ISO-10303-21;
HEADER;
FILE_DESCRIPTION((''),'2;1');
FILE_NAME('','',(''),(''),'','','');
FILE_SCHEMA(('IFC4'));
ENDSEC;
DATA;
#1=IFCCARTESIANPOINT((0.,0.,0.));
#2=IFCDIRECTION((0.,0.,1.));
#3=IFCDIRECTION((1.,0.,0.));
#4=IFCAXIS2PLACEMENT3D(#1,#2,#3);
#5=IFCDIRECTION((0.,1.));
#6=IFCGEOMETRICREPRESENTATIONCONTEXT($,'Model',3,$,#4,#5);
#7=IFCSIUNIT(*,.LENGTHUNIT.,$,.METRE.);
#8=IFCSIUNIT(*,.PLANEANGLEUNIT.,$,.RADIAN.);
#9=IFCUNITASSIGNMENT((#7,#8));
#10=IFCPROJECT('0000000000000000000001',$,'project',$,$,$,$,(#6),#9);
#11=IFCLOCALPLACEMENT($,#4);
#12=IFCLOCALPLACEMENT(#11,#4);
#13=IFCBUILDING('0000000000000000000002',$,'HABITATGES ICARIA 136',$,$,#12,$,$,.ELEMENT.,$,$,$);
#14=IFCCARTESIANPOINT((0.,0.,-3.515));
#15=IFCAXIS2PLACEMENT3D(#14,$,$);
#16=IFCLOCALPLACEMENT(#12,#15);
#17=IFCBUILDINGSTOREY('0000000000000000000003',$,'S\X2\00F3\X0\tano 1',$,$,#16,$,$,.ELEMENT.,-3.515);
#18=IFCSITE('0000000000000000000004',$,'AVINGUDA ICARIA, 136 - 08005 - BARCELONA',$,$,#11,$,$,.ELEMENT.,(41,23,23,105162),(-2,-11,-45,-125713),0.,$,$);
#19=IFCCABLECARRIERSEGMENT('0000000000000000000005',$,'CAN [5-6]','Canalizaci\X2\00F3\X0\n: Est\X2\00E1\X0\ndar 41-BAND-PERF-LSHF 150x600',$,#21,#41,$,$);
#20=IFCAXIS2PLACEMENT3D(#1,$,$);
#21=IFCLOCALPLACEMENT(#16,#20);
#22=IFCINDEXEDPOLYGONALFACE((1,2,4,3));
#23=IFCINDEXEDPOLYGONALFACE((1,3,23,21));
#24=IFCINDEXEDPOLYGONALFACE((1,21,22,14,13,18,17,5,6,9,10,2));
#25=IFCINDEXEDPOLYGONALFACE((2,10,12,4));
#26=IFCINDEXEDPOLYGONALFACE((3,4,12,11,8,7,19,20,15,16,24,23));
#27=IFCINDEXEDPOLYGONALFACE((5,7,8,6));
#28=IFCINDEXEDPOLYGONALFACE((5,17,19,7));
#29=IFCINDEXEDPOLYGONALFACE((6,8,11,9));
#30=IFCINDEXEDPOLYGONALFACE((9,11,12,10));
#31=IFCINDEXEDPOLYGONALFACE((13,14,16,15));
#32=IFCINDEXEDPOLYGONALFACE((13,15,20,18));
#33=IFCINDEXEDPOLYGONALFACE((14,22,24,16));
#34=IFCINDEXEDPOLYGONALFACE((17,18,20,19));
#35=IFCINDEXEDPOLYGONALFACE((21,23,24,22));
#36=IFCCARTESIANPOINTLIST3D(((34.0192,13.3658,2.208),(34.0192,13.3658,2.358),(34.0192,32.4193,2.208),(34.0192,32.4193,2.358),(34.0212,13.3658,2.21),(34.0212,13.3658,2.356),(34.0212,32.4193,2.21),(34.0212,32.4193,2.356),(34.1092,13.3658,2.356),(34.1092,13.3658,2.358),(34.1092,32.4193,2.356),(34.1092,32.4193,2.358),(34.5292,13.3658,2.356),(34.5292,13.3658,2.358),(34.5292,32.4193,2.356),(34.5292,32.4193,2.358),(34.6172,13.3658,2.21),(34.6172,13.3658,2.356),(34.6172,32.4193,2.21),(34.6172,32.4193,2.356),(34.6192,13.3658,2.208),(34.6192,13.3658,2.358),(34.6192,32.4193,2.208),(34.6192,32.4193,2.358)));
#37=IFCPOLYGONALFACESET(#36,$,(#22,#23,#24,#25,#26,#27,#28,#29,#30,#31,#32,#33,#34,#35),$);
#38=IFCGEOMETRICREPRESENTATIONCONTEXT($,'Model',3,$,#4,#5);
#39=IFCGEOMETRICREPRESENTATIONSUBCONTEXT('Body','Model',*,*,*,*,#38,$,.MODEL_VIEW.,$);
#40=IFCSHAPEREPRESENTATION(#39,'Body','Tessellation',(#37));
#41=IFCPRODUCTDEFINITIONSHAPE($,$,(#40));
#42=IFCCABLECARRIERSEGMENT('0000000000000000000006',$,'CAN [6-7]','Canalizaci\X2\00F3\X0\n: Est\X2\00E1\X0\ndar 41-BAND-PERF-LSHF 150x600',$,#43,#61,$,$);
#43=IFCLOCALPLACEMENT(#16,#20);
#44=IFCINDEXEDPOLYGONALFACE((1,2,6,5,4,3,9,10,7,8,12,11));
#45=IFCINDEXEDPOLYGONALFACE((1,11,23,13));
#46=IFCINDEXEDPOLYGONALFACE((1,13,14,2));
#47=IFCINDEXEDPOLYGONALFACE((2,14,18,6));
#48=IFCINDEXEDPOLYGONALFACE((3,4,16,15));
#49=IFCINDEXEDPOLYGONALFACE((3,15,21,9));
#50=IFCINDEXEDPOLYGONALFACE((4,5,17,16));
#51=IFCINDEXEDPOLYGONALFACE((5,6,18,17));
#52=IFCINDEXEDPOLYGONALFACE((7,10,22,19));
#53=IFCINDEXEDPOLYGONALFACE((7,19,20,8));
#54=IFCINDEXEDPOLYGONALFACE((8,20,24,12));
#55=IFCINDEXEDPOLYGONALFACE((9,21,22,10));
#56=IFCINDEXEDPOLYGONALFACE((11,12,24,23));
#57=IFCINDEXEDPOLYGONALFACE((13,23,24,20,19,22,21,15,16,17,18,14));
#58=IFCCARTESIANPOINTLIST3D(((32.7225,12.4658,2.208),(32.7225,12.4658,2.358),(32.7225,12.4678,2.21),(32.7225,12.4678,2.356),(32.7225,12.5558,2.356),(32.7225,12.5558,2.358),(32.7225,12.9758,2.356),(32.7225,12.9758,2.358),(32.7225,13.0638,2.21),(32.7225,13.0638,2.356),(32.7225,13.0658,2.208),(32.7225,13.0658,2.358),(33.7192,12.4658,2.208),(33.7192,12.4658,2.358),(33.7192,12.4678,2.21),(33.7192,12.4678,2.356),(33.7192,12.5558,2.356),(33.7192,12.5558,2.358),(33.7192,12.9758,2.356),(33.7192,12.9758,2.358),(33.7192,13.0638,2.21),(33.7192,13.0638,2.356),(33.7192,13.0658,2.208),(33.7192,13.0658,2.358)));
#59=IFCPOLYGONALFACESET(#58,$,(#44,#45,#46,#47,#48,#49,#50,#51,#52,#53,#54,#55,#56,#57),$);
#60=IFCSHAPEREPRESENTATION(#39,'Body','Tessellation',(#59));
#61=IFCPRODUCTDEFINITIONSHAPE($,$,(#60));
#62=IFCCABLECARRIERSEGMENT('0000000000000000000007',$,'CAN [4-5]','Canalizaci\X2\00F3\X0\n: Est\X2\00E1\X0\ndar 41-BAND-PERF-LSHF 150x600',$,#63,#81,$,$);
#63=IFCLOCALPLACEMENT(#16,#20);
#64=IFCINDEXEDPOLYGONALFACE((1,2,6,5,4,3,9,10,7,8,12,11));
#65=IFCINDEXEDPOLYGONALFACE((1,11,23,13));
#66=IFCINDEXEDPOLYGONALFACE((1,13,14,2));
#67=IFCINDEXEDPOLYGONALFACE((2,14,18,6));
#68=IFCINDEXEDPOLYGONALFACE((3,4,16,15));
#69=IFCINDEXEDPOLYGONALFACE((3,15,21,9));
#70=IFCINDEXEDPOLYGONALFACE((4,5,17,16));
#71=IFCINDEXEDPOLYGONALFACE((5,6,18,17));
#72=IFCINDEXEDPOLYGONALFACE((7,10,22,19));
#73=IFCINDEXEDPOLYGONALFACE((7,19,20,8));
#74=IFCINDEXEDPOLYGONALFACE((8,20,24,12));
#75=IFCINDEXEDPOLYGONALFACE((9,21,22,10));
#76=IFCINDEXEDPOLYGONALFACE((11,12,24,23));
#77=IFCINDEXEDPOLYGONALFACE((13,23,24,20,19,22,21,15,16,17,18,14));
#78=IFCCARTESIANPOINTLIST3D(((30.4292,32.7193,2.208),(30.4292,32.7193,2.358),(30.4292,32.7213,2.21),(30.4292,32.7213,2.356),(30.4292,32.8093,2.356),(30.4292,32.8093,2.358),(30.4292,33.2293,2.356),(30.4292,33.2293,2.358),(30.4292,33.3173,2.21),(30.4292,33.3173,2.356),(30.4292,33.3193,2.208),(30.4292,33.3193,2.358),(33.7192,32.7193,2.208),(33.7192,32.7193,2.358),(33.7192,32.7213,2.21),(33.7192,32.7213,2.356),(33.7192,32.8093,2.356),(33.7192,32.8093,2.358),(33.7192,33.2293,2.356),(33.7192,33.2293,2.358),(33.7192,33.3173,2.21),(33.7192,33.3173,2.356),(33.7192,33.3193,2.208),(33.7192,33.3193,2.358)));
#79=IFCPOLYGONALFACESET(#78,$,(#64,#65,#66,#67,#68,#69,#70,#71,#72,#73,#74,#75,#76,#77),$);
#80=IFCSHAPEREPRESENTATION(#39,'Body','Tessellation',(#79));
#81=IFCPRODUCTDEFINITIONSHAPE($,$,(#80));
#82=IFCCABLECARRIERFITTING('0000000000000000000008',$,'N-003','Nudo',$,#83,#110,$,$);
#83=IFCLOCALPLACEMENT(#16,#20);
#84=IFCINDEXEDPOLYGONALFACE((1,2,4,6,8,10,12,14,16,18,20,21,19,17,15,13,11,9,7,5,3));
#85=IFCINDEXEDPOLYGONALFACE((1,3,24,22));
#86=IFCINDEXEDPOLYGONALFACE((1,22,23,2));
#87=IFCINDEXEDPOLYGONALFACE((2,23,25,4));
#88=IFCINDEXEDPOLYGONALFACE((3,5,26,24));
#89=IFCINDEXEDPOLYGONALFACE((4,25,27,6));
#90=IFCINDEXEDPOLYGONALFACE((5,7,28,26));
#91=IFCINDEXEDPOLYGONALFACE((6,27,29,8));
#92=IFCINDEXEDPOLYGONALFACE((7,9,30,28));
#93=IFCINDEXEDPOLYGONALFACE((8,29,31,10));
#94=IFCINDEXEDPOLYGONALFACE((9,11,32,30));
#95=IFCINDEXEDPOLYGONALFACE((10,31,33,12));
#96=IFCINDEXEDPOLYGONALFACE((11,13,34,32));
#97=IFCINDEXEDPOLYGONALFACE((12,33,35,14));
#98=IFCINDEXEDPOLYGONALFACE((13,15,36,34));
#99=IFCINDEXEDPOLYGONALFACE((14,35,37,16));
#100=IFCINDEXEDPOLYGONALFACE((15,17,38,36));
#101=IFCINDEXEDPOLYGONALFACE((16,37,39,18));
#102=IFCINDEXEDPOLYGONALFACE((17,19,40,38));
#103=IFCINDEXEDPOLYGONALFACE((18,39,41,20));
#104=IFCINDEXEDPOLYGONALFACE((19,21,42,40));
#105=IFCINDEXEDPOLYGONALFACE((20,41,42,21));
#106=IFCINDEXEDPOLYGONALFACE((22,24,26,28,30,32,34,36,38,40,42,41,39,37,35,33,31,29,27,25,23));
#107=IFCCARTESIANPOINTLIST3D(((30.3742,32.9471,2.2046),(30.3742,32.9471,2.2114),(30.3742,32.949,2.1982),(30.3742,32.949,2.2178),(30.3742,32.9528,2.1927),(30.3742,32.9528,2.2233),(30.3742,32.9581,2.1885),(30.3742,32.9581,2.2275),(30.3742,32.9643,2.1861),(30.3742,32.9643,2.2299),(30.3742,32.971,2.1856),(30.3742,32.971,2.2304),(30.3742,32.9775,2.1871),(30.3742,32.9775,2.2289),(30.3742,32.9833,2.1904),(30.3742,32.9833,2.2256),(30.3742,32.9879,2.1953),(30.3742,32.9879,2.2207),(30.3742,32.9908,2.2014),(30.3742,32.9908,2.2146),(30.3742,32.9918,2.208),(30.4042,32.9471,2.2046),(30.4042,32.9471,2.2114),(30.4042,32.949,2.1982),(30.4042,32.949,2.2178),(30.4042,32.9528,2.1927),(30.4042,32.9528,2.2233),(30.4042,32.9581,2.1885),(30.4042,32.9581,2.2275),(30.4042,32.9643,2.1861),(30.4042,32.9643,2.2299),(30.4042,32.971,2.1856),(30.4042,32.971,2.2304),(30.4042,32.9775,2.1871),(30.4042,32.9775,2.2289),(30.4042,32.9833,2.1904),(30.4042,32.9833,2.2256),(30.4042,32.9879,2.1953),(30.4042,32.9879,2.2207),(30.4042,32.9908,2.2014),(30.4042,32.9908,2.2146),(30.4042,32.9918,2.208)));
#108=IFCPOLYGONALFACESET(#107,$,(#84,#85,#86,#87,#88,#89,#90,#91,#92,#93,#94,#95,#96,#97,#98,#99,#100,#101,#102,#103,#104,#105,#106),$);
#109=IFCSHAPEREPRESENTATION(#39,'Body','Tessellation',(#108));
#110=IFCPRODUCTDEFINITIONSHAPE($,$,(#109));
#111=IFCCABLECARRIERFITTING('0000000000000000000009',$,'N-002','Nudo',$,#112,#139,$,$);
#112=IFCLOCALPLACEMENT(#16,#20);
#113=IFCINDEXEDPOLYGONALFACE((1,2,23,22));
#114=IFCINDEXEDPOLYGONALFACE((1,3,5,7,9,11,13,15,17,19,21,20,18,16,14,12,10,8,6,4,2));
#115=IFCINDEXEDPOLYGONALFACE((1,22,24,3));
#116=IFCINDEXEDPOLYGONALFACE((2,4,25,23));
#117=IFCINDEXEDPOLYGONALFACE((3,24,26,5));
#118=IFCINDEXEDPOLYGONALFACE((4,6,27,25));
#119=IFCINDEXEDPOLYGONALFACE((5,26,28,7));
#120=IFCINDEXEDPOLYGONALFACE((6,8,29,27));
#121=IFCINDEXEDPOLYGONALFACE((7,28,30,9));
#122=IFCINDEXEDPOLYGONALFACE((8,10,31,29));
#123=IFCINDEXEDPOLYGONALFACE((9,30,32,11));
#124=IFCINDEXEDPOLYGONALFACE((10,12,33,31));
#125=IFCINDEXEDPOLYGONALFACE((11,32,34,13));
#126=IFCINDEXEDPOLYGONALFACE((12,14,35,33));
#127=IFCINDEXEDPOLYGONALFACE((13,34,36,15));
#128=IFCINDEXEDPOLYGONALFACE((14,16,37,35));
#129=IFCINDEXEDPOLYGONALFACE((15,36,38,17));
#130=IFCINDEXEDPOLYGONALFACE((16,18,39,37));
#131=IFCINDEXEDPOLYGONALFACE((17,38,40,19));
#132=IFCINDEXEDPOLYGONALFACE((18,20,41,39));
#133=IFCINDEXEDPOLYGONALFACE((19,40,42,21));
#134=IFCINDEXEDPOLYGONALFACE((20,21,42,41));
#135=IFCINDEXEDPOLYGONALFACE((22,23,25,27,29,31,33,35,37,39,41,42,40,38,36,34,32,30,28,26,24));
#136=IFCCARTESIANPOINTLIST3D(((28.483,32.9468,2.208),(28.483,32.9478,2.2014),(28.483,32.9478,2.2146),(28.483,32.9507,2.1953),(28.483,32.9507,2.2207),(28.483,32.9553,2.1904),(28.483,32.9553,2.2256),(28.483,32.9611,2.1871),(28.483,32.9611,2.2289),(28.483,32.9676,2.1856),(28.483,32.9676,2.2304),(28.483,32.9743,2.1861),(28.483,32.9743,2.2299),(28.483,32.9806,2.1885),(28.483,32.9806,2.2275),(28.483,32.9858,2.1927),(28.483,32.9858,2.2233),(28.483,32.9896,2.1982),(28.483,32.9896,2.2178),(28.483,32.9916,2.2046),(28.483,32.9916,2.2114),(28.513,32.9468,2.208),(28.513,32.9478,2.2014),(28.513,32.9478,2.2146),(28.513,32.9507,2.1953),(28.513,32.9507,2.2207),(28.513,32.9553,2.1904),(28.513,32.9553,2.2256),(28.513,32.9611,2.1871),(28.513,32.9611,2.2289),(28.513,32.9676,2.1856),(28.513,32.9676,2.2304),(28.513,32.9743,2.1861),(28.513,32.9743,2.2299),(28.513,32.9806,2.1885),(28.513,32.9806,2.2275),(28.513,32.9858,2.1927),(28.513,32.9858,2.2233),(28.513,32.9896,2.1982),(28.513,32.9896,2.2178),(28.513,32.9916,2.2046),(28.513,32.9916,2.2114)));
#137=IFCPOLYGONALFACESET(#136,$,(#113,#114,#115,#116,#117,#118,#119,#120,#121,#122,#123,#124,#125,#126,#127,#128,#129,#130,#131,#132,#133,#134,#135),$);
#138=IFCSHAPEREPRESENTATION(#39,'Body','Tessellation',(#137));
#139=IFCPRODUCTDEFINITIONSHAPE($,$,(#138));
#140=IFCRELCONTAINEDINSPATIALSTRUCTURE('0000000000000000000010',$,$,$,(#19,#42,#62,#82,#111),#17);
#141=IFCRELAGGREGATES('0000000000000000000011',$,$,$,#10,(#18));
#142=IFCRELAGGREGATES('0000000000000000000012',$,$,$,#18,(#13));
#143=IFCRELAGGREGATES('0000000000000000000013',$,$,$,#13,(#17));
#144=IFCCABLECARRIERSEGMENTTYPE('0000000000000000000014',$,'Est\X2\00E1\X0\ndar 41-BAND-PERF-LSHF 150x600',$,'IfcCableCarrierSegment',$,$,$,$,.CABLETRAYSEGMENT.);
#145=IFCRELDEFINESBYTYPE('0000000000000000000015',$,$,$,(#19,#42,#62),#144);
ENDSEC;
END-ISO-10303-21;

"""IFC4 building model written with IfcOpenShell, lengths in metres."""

from ifc_helpers import new_model, si_unit, direction, frame, origin_with_axes, origin_2d_with_axis, place, context, subcontext, project, spatial, polyline, circle, outline, extrude, source, transform, mapped, type_object, element, save


model = new_model("IFC4")

# Units and contexts
model_context_1 = context("Model", 3, world=origin_with_axes(), true_north=direction((0.0, 1.0)))
model_context_2 = context("Model", 3, world=origin_with_axes(), true_north=direction((0.0, 1.0)))
body_context_1 = subcontext(model_context_2, "Body", "Model", "MODEL_VIEW")
ifc_project = project(units=[si_unit("LENGTHUNIT", "METRE"), si_unit("PLANEANGLEUNIT", "RADIAN")], contexts=[model_context_1])

# Site, building, storey
site_placement = place(None, origin_with_axes())
site = spatial("IfcSite", under=ifc_project, at=site_placement, Name="AVINGUDA ICARIA, 136 - 08005 - BARCELONA", CompositionType="ELEMENT", RefLatitude=(41, 23, 23, 105162), RefLongitude=(-2, -11, -45, -125713), RefElevation=0.0)
building_placement = place(site_placement, origin_with_axes())
building = spatial("IfcBuilding", under=site, at=building_placement, Name="HABITATGES ICARIA 136", CompositionType="ELEMENT")
storey_placement = place(building_placement, frame((0.0, 0.0, -3.515)))
storey = spatial("IfcBuildingStorey", under=building, at=storey_placement, Name="Sótano 1", CompositionType="ELEMENT", Elevation=-3.515)

# Cable carrier segments
cable_carrier_segment_type_1 = type_object("IfcCableCarrierSegmentType", Name="Estándar 41-BAND-PERF-LSHF 150x600", ApplicableOccurrence="IfcCableCarrierSegment", PredefinedType="CABLETRAYSEGMENT")
placement_1 = place(None, origin_with_axes())
placement_2 = place(placement_1, origin_with_axes())
placement_3 = place(placement_2, frame((0.0, 0.0, -3.515)))
cable_carrier_segment_1_placement = place(placement_3, origin_with_axes())
element("IfcCableCarrierSegment", 1, at=cable_carrier_segment_1_placement, inside=storey, type_object=cable_carrier_segment_type_1, Name="CAN [5-6]", Description="Canalización: Estándar 41-BAND-PERF-LSHF 150x600", context=body_context_1, shape_type="SweptSolid", body=[
    extrude(outline(polyline([(-0.21, 0.148), (-0.21, 0.15), (-0.3, 0.15), (-0.3, 0.0), (0.3, 0.0), (0.3, 0.15), (0.21, 0.15), (0.21, 0.148), (0.298, 0.148), (0.298, 0.002), (-0.298, 0.002), (-0.298, 0.148), (-0.21, 0.148)])), frame((34.3192, 32.4193, 2.208), z_axis=(0.0, -1.0, 0.0), x_axis=(1.0, 0.0, 0.0)), (0.0, 0.0, 1.0), 19.0536),
])
cable_carrier_segment_2_placement = place(placement_3, origin_with_axes())
element("IfcCableCarrierSegment", 2, at=cable_carrier_segment_2_placement, inside=storey, type_object=cable_carrier_segment_type_1, Name="CAN [6-7]", Description="Canalización: Estándar 41-BAND-PERF-LSHF 150x600", context=body_context_1, shape_type="SweptSolid", body=[
    extrude(outline(polyline([(-0.21, 0.148), (-0.21, 0.15), (-0.3, 0.15), (-0.3, 0.0), (0.3, 0.0), (0.3, 0.15), (0.21, 0.15), (0.21, 0.148), (0.298, 0.148), (0.298, 0.002), (-0.298, 0.002), (-0.298, 0.148), (-0.21, 0.148)])), frame((33.7192, 12.7658, 2.208), z_axis=(-1.0, 0.0, 0.0), x_axis=(0.0, -1.0, 0.0)), (0.0, 0.0, 1.0), 0.9967),
])
cable_carrier_segment_3_placement = place(placement_3, origin_with_axes())
element("IfcCableCarrierSegment", 3, at=cable_carrier_segment_3_placement, inside=storey, type_object=cable_carrier_segment_type_1, Name="CAN [4-5]", Description="Canalización: Estándar 41-BAND-PERF-LSHF 150x600", context=body_context_1, shape_type="SweptSolid", body=[
    extrude(outline(polyline([(-0.21, 0.148), (-0.21, 0.15), (-0.3, 0.15), (-0.3, 0.0), (0.3, 0.0), (0.3, 0.15), (0.21, 0.15), (0.21, 0.148), (0.298, 0.148), (0.298, 0.002), (-0.298, 0.002), (-0.298, 0.148), (-0.21, 0.148)])), frame((30.4292, 33.0193, 2.208), z_axis=(1.0, 0.0, 0.0), x_axis=(0.0, 1.0, 0.0)), (0.0, 0.0, 1.0), 3.29),
])

# Cable carrier fittings
shared_shape_1 = source(origin_with_axes(), body_context_1, "Body", "SweptSolid", [
    extrude(circle(Radius=0.0225, at=origin_2d_with_axis()), frame((0.0, -0.03, 0.0), z_axis=(0.0, 1.0, 0.0), x_axis=(-1.0, 0.0, 0.0)), (0.0, 0.0, 1.0), 0.03),
])
cable_carrier_fitting_1_placement = place(placement_3, origin_with_axes())
element("IfcCableCarrierFitting", 4, at=cable_carrier_fitting_1_placement, inside=storey, Name="N-003", Description="Nudo", context=body_context_1, shape_type="MappedRepresentation", body=[
    mapped(shared_shape_1, transform((30.4042, 32.9693, 2.208), x_axis=(0.0, -1.0, 0.0), y_axis=(1.0, 0.0, 0.0), z_axis=(0.0, 0.0, 1.0), scale=1.0)),
])
cable_carrier_fitting_2_placement = place(placement_3, origin_with_axes())
element("IfcCableCarrierFitting", 5, at=cable_carrier_fitting_2_placement, inside=storey, Name="N-002", Description="Nudo", context=body_context_1, shape_type="MappedRepresentation", body=[
    mapped(shared_shape_1, transform((28.483, 32.9693, 2.208), x_axis=(0.0, 1.0, 0.0), y_axis=(-1.0, 0.0, 0.0), z_axis=(0.0, 0.0, 1.0), scale=1.0)),
])

save(model, "model.ifc")
